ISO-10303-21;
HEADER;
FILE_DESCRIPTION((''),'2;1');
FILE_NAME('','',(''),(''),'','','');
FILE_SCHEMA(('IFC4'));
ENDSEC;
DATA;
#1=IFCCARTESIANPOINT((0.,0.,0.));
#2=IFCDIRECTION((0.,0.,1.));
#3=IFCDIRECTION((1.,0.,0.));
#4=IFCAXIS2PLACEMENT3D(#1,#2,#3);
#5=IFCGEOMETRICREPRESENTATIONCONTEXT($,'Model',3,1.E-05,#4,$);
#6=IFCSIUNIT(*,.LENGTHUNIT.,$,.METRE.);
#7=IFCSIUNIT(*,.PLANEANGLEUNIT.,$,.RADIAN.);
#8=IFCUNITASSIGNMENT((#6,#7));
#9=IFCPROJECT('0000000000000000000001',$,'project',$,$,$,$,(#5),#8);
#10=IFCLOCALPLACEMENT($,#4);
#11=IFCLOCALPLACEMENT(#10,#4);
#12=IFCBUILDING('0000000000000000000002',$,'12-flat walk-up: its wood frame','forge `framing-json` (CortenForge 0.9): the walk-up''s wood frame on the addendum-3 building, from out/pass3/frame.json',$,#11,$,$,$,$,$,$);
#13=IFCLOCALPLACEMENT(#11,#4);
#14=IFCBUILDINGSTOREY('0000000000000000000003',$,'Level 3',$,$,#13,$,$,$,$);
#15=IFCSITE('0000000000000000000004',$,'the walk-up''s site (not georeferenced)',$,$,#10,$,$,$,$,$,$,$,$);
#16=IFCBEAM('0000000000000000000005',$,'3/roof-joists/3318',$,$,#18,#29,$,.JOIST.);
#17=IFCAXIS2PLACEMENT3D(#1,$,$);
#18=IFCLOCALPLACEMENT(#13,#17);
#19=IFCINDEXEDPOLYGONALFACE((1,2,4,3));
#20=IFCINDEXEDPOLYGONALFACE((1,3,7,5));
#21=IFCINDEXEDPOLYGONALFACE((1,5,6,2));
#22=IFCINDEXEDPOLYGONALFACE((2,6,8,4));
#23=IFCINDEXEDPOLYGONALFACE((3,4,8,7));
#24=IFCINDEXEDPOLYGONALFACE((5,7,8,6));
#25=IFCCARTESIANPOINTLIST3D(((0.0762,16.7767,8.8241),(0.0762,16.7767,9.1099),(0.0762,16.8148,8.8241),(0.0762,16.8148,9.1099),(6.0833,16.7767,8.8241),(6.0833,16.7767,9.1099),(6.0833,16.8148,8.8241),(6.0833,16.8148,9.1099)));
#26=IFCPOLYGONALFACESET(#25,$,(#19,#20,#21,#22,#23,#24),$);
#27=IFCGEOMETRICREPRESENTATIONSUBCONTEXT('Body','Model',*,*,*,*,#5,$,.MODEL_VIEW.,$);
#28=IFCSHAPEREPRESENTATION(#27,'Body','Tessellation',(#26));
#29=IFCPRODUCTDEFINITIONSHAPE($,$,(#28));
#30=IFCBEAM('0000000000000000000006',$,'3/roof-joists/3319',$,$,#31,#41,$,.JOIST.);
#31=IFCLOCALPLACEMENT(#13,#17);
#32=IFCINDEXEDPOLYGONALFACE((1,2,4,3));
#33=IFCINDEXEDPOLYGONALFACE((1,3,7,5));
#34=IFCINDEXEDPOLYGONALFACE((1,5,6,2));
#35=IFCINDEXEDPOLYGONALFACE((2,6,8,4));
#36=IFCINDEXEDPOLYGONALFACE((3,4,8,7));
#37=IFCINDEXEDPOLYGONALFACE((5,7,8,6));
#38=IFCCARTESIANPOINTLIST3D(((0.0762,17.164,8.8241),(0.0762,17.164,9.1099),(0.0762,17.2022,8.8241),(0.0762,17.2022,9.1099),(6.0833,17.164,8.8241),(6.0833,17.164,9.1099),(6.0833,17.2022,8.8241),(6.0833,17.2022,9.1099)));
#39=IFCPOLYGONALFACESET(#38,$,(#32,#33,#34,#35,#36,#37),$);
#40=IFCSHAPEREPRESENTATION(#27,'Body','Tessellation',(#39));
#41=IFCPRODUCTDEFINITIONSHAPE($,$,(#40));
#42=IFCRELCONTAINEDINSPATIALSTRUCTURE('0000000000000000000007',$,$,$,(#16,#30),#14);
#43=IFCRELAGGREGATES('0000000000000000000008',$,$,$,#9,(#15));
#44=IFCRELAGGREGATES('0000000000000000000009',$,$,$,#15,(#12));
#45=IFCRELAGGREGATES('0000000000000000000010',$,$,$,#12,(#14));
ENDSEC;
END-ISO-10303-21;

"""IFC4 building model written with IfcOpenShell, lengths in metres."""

from ifc_helpers import new_model, si_unit, frame, frame_2d, origin, origin_with_axes, place, context, subcontext, project, spatial, rectangle, extrude, element, save


model = new_model("IFC4")

# Units and contexts
model_context = context("Model", 3, precision=1e-05, world=origin_with_axes())
body_context = subcontext(model_context, "Body", "Model", "MODEL_VIEW")
ifc_project = project(units=[si_unit("LENGTHUNIT", "METRE"), si_unit("PLANEANGLEUNIT", "RADIAN")], contexts=[model_context])

# Site, building, storey
site_placement = place(None, origin_with_axes())
site = spatial("IfcSite", under=ifc_project, at=site_placement, Name="the walk-up's site (not georeferenced)")
building_placement = place(site_placement, origin_with_axes())
building = spatial("IfcBuilding", under=site, at=building_placement, Name="12-flat walk-up: its wood frame", Description="forge `framing-json` (CortenForge 0.9): the walk-up's wood frame on the addendum-3 building, from out/pass3/frame.json")
storey_placement = place(building_placement, origin_with_axes())
storey = spatial("IfcBuildingStorey", under=building, at=storey_placement, Name="Level 3")

# Beams
for number, where, z_axis, x_axis, name in (
    (1, (0.0762, 16.7767, 8.8241), (0.0, 0.0, 1.0), (1.0, 0.0, 0.0), "3/roof-joists/3318"),
    (2, (0.0762, 17.164, 8.8241), (0.0, 0.0, 1.0), (1.0, 0.0, 0.0), "3/roof-joists/3319"),
):
    element("IfcBeam", number, at=place(storey_placement, frame(where, z_axis=z_axis, x_axis=x_axis)), inside=storey, Name=name, PredefinedType="JOIST", context=body_context, shape_type="SweptSolid", body=[
        extrude(rectangle(XDim=6.0071, YDim=0.0381, at=frame_2d((3.0036, 0.0191))), origin(), (0.0, 0.0, 1.0), 0.2858),
    ])

save(model, "model.ifc")
